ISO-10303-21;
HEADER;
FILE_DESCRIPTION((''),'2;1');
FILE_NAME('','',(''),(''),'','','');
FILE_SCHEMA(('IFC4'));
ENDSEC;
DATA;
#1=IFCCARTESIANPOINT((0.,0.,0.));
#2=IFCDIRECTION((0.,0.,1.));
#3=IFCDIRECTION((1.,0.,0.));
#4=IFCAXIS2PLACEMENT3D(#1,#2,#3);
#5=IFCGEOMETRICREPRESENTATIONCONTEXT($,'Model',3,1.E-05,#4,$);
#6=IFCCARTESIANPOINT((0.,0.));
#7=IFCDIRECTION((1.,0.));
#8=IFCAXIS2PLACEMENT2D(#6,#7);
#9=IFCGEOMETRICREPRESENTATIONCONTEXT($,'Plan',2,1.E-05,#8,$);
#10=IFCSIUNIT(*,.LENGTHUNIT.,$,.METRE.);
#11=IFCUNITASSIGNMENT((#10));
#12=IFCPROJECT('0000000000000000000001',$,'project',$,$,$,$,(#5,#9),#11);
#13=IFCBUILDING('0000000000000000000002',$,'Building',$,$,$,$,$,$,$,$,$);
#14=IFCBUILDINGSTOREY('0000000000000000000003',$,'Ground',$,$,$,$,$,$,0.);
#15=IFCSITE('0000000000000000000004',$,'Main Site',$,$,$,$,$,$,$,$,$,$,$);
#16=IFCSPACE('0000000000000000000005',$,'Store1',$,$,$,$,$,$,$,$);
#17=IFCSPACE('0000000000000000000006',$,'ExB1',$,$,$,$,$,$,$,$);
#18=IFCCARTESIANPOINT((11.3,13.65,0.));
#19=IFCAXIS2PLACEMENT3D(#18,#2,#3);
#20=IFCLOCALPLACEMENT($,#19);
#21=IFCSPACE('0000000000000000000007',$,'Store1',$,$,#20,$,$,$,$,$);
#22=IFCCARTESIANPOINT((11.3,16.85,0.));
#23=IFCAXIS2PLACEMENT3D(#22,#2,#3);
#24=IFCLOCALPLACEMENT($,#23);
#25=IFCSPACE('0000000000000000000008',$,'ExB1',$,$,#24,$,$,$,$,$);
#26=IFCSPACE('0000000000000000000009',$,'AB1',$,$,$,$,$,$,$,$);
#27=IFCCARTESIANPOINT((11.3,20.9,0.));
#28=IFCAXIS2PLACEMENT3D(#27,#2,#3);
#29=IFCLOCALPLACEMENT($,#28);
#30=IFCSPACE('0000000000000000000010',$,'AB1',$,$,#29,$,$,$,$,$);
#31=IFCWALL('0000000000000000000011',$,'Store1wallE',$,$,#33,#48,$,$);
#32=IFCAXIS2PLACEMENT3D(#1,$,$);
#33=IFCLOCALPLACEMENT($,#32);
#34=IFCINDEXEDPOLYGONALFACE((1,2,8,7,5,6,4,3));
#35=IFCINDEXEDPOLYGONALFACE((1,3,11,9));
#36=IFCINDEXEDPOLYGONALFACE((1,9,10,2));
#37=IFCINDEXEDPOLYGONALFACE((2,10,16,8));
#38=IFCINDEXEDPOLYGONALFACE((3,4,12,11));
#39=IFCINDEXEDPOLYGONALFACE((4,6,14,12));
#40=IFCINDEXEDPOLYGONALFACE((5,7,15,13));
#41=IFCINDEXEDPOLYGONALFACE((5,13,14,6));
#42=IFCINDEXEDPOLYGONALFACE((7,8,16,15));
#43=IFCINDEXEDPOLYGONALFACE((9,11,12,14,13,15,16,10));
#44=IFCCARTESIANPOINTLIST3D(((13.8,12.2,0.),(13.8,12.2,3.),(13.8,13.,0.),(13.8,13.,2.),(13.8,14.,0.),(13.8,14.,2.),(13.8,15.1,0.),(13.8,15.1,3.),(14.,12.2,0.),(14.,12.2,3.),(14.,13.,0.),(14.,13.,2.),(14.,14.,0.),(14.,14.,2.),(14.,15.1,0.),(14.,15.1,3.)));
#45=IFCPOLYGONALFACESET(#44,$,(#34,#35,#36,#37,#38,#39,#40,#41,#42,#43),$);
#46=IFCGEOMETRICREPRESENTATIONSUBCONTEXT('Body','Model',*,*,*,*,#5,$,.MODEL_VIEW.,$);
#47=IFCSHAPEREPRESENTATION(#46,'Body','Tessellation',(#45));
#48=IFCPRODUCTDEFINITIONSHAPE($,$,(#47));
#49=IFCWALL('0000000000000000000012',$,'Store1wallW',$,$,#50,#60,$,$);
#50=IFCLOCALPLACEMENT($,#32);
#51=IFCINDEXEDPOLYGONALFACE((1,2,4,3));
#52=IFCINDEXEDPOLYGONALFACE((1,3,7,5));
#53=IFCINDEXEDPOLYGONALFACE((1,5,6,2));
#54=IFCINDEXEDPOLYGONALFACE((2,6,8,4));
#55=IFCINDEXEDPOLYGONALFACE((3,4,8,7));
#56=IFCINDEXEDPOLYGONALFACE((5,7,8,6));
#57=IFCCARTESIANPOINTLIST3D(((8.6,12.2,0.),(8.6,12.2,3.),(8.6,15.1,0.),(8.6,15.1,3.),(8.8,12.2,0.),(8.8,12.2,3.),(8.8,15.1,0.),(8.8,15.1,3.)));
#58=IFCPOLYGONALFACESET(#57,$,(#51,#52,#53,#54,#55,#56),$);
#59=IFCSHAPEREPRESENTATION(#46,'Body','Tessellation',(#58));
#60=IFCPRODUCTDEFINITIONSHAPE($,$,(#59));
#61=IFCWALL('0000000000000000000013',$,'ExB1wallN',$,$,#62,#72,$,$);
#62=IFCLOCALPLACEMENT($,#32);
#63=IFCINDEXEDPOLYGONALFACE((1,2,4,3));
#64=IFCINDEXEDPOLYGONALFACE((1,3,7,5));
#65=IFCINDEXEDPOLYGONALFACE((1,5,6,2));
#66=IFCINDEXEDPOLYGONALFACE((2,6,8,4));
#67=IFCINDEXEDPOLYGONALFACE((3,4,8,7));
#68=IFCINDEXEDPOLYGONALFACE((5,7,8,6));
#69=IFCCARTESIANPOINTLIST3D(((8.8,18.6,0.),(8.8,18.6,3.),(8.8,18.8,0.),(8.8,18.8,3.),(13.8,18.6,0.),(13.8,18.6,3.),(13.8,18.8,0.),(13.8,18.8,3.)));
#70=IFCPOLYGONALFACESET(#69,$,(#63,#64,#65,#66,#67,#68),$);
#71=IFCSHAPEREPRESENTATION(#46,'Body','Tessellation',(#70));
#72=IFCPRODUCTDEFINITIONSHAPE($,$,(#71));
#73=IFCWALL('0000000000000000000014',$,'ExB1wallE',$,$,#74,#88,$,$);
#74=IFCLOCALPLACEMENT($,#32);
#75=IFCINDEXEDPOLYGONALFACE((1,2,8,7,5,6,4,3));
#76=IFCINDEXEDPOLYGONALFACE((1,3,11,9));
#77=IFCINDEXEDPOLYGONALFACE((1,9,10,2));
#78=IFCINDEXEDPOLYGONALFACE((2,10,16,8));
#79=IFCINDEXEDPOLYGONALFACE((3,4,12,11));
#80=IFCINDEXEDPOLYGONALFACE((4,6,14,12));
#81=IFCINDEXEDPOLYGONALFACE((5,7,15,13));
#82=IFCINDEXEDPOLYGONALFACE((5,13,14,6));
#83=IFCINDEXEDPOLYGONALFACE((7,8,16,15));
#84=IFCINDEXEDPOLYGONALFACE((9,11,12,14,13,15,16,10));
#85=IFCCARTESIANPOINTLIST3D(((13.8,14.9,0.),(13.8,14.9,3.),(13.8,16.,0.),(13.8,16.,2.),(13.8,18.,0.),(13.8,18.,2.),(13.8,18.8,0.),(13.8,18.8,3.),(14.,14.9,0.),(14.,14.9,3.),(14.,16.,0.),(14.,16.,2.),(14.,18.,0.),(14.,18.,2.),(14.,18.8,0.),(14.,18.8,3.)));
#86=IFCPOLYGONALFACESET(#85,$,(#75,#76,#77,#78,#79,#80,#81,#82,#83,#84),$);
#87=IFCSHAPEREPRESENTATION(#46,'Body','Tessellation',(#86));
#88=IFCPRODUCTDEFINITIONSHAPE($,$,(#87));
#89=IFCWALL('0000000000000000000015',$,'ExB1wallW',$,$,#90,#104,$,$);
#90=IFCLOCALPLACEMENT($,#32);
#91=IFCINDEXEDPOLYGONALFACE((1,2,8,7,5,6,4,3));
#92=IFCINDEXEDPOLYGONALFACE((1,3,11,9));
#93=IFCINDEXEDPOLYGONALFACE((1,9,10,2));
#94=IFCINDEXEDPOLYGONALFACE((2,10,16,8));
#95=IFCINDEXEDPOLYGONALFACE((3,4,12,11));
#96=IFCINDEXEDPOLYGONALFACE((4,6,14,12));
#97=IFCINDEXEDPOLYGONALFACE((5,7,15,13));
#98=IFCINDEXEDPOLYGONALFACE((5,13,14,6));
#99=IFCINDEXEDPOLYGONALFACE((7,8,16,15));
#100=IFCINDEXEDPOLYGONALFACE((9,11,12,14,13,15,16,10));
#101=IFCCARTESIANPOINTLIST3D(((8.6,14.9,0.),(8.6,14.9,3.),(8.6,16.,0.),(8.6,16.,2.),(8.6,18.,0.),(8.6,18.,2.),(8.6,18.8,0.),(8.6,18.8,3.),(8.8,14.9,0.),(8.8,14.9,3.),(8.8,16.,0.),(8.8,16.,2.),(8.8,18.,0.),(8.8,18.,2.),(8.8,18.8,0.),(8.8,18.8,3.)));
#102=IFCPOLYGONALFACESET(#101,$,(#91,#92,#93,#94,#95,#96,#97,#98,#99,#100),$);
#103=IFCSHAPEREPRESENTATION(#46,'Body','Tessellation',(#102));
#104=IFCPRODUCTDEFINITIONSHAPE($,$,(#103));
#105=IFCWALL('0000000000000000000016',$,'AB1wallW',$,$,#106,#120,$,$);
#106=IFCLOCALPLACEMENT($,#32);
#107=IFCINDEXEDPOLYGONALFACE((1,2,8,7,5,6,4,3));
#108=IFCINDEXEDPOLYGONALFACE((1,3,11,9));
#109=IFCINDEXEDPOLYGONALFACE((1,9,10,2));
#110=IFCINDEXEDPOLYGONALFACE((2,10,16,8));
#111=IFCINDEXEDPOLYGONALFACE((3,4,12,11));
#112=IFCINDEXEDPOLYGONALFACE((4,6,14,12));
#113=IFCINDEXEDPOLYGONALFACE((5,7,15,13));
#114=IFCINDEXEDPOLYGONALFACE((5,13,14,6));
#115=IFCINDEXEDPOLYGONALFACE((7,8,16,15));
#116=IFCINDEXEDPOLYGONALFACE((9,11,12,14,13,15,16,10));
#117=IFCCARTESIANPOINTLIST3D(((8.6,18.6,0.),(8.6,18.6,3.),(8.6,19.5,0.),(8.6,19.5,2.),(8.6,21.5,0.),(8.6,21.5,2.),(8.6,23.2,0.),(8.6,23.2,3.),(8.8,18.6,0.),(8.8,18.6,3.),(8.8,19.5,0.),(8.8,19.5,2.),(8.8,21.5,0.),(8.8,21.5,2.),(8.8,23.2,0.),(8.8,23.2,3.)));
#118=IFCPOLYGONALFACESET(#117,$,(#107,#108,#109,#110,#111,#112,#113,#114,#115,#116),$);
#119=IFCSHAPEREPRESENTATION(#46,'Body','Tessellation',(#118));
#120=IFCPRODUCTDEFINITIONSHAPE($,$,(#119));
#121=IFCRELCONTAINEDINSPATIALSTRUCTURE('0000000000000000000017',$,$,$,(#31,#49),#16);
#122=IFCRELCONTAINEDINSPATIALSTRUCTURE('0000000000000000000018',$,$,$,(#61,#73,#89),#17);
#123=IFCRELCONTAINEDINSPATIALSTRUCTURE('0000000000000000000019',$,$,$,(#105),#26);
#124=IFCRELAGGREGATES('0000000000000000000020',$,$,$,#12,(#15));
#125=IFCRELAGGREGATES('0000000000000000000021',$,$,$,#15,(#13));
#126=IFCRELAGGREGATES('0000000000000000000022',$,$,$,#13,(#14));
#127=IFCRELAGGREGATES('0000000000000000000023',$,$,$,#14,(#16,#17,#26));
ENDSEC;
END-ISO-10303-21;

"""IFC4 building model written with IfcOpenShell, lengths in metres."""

from ifc_helpers import new_model, si_unit, frame, origin_with_axes, origin_2d_with_axis, place, context, subcontext, project, spatial, indexed_curve, outline, extrude, element, save


model = new_model("IFC4")

# Units and contexts
model_context = context("Model", 3, precision=1e-05, world=origin_with_axes())
plan_context = context("Plan", 2, precision=1e-05, world=origin_2d_with_axis())
body_context = subcontext(model_context, "Body", "Model", "MODEL_VIEW")
ifc_project = project(units=[si_unit("LENGTHUNIT", "METRE")], contexts=[model_context, plan_context])

# Site, building, storey
site = spatial("IfcSite", under=ifc_project, Name="Main Site")
building = spatial("IfcBuilding", under=site, Name="Building")
storey = spatial("IfcBuildingStorey", under=building, Name="Ground", Elevation=0.0)

# Shared definitions
space_1 = spatial("IfcSpace", under=storey, Name="Store1")

# Shared definitions
space_2 = spatial("IfcSpace", under=storey, Name="ExB1")

# Wall
wall_1_placement = place(None, frame((14.0, 12.2, 0.0), z_axis=(0.0, 0.0, 1.0), x_axis=(0.0, 1.0, 0.0)))
wall_1 = element("IfcWall", 1, at=wall_1_placement, inside=space_1, Name="Store1wallE", context=body_context, shape_type="SweptSolid", body=[
    extrude(outline(indexed_curve([(0.0, 0.0), (0.0, 0.2), (2.9, 0.2), (2.9, 0.0), (0.0, 0.0)], self_intersect=False)), origin_with_axes(), (0.0, 0.0, 1.0), 3.0),
])

# Shared definitions
space_3_placement = place(None, frame((11.3, 13.65, 0.0), z_axis=(0.0, 0.0, 1.0), x_axis=(1.0, 0.0, 0.0)))
space_3 = spatial("IfcSpace", at=space_3_placement, Name="Store1")

# Opening
opening_1_placement = place(wall_1_placement, frame((0.8, 0.0, 0.0), z_axis=(0.0, 0.0, 1.0), x_axis=(1.0, 0.0, 0.0)))
element("IfcOpeningElement", 2, at=opening_1_placement, inside=space_3, cuts=wall_1, context=body_context, shape_type="SweptSolid", body=[
    extrude(outline(indexed_curve([(0.0, 0.0), (0.0, 0.4), (1.0, 0.4), (1.0, 0.0), (0.0, 0.0)], self_intersect=False)), origin_with_axes(), (0.0, 0.0, 1.0), 2.0),
])

# Walls
wall_2_placement = place(None, frame((8.8, 12.2, 0.0), z_axis=(0.0, 0.0, 1.0), x_axis=(0.0, 1.0, 0.0)))
element("IfcWall", 3, at=wall_2_placement, inside=space_1, Name="Store1wallW", context=body_context, shape_type="SweptSolid", body=[
    extrude(outline(indexed_curve([(0.0, 0.0), (0.0, 0.2), (2.9, 0.2), (2.9, 0.0), (0.0, 0.0)], self_intersect=False)), origin_with_axes(), (0.0, 0.0, 1.0), 3.0),
])
for number, where, z_axis, x_axis, name in (
    (4, (8.8, 18.6, 0.0), (0.0, 0.0, 1.0), (1.0, 0.0, 0.0), "ExB1wallN"),
):
    element("IfcWall", number, at=place(None, frame(where, z_axis=z_axis, x_axis=x_axis)), inside=space_2, Name=name, context=body_context, shape_type="SweptSolid", body=[
        extrude(outline(indexed_curve([(0.0, 0.0), (0.0, 0.2), (5.0, 0.2), (5.0, 0.0), (0.0, 0.0)], self_intersect=False)), origin_with_axes(), (0.0, 0.0, 1.0), 3.0),
    ])

# Wall
wall_3_placement = place(None, frame((14.0, 14.9, 0.0), z_axis=(0.0, 0.0, 1.0), x_axis=(0.0, 1.0, 0.0)))
wall_3 = element("IfcWall", 5, at=wall_3_placement, inside=space_2, Name="ExB1wallE", context=body_context, shape_type="SweptSolid", body=[
    extrude(outline(indexed_curve([(0.0, 0.0), (0.0, 0.2), (3.9, 0.2), (3.9, 0.0), (0.0, 0.0)], self_intersect=False)), origin_with_axes(), (0.0, 0.0, 1.0), 3.0),
])

# Shared definitions
space_4_placement = place(None, frame((11.3, 16.85, 0.0), z_axis=(0.0, 0.0, 1.0), x_axis=(1.0, 0.0, 0.0)))
space_4 = spatial("IfcSpace", at=space_4_placement, Name="ExB1")

# Opening
opening_2_placement = place(wall_3_placement, frame((1.1, 0.0, 0.0), z_axis=(0.0, 0.0, 1.0), x_axis=(1.0, 0.0, 0.0)))
element("IfcOpeningElement", 6, at=opening_2_placement, inside=space_4, cuts=wall_3, context=body_context, shape_type="SweptSolid", body=[
    extrude(outline(indexed_curve([(0.0, 0.0), (0.0, 0.4), (2.0, 0.4), (2.0, 0.0), (0.0, 0.0)], self_intersect=False)), origin_with_axes(), (0.0, 0.0, 1.0), 2.0),
])

# Wall, opening
wall_4_placement = place(None, frame((8.8, 14.9, 0.0), z_axis=(0.0, 0.0, 1.0), x_axis=(0.0, 1.0, 0.0)))
wall_4 = element("IfcWall", 7, at=wall_4_placement, inside=space_2, Name="ExB1wallW", context=body_context, shape_type="SweptSolid", body=[
    extrude(outline(indexed_curve([(0.0, 0.0), (0.0, 0.2), (3.9, 0.2), (3.9, 0.0), (0.0, 0.0)], self_intersect=False)), origin_with_axes(), (0.0, 0.0, 1.0), 3.0),
])
opening_3_placement = place(wall_4_placement, frame((1.1, 0.0, 0.0), z_axis=(0.0, 0.0, 1.0), x_axis=(1.0, 0.0, 0.0)))
element("IfcOpeningElement", 8, at=opening_3_placement, inside=space_4, cuts=wall_4, context=body_context, shape_type="SweptSolid", body=[
    extrude(outline(indexed_curve([(0.0, 0.0), (0.0, 0.4), (2.0, 0.4), (2.0, 0.0), (0.0, 0.0)], self_intersect=False)), origin_with_axes(), (0.0, 0.0, 1.0), 2.0),
])

# Shared definitions
space_5 = spatial("IfcSpace", under=storey, Name="AB1")

# Wall
wall_5_placement = place(None, frame((8.8, 18.6, 0.0), z_axis=(0.0, 0.0, 1.0), x_axis=(0.0, 1.0, 0.0)))
wall_5 = element("IfcWall", 9, at=wall_5_placement, inside=space_5, Name="AB1wallW", context=body_context, shape_type="SweptSolid", body=[
    extrude(outline(indexed_curve([(0.0, 0.0), (0.0, 0.2), (4.6, 0.2), (4.6, 0.0), (0.0, 0.0)], self_intersect=False)), origin_with_axes(), (0.0, 0.0, 1.0), 3.0),
])

# Shared definitions
space_6_placement = place(None, frame((11.3, 20.9, 0.0), z_axis=(0.0, 0.0, 1.0), x_axis=(1.0, 0.0, 0.0)))
space_6 = spatial("IfcSpace", at=space_6_placement, Name="AB1")

# Opening
opening_4_placement = place(wall_5_placement, frame((0.9, 0.0, 0.0), z_axis=(0.0, 0.0, 1.0), x_axis=(1.0, 0.0, 0.0)))
element("IfcOpeningElement", 10, at=opening_4_placement, inside=space_6, cuts=wall_5, context=body_context, shape_type="SweptSolid", body=[
    extrude(outline(indexed_curve([(0.0, 0.0), (0.0, 0.4), (2.0, 0.4), (2.0, 0.0), (0.0, 0.0)], self_intersect=False)), origin_with_axes(), (0.0, 0.0, 1.0), 2.0),
])

save(model, "model.ifc")
